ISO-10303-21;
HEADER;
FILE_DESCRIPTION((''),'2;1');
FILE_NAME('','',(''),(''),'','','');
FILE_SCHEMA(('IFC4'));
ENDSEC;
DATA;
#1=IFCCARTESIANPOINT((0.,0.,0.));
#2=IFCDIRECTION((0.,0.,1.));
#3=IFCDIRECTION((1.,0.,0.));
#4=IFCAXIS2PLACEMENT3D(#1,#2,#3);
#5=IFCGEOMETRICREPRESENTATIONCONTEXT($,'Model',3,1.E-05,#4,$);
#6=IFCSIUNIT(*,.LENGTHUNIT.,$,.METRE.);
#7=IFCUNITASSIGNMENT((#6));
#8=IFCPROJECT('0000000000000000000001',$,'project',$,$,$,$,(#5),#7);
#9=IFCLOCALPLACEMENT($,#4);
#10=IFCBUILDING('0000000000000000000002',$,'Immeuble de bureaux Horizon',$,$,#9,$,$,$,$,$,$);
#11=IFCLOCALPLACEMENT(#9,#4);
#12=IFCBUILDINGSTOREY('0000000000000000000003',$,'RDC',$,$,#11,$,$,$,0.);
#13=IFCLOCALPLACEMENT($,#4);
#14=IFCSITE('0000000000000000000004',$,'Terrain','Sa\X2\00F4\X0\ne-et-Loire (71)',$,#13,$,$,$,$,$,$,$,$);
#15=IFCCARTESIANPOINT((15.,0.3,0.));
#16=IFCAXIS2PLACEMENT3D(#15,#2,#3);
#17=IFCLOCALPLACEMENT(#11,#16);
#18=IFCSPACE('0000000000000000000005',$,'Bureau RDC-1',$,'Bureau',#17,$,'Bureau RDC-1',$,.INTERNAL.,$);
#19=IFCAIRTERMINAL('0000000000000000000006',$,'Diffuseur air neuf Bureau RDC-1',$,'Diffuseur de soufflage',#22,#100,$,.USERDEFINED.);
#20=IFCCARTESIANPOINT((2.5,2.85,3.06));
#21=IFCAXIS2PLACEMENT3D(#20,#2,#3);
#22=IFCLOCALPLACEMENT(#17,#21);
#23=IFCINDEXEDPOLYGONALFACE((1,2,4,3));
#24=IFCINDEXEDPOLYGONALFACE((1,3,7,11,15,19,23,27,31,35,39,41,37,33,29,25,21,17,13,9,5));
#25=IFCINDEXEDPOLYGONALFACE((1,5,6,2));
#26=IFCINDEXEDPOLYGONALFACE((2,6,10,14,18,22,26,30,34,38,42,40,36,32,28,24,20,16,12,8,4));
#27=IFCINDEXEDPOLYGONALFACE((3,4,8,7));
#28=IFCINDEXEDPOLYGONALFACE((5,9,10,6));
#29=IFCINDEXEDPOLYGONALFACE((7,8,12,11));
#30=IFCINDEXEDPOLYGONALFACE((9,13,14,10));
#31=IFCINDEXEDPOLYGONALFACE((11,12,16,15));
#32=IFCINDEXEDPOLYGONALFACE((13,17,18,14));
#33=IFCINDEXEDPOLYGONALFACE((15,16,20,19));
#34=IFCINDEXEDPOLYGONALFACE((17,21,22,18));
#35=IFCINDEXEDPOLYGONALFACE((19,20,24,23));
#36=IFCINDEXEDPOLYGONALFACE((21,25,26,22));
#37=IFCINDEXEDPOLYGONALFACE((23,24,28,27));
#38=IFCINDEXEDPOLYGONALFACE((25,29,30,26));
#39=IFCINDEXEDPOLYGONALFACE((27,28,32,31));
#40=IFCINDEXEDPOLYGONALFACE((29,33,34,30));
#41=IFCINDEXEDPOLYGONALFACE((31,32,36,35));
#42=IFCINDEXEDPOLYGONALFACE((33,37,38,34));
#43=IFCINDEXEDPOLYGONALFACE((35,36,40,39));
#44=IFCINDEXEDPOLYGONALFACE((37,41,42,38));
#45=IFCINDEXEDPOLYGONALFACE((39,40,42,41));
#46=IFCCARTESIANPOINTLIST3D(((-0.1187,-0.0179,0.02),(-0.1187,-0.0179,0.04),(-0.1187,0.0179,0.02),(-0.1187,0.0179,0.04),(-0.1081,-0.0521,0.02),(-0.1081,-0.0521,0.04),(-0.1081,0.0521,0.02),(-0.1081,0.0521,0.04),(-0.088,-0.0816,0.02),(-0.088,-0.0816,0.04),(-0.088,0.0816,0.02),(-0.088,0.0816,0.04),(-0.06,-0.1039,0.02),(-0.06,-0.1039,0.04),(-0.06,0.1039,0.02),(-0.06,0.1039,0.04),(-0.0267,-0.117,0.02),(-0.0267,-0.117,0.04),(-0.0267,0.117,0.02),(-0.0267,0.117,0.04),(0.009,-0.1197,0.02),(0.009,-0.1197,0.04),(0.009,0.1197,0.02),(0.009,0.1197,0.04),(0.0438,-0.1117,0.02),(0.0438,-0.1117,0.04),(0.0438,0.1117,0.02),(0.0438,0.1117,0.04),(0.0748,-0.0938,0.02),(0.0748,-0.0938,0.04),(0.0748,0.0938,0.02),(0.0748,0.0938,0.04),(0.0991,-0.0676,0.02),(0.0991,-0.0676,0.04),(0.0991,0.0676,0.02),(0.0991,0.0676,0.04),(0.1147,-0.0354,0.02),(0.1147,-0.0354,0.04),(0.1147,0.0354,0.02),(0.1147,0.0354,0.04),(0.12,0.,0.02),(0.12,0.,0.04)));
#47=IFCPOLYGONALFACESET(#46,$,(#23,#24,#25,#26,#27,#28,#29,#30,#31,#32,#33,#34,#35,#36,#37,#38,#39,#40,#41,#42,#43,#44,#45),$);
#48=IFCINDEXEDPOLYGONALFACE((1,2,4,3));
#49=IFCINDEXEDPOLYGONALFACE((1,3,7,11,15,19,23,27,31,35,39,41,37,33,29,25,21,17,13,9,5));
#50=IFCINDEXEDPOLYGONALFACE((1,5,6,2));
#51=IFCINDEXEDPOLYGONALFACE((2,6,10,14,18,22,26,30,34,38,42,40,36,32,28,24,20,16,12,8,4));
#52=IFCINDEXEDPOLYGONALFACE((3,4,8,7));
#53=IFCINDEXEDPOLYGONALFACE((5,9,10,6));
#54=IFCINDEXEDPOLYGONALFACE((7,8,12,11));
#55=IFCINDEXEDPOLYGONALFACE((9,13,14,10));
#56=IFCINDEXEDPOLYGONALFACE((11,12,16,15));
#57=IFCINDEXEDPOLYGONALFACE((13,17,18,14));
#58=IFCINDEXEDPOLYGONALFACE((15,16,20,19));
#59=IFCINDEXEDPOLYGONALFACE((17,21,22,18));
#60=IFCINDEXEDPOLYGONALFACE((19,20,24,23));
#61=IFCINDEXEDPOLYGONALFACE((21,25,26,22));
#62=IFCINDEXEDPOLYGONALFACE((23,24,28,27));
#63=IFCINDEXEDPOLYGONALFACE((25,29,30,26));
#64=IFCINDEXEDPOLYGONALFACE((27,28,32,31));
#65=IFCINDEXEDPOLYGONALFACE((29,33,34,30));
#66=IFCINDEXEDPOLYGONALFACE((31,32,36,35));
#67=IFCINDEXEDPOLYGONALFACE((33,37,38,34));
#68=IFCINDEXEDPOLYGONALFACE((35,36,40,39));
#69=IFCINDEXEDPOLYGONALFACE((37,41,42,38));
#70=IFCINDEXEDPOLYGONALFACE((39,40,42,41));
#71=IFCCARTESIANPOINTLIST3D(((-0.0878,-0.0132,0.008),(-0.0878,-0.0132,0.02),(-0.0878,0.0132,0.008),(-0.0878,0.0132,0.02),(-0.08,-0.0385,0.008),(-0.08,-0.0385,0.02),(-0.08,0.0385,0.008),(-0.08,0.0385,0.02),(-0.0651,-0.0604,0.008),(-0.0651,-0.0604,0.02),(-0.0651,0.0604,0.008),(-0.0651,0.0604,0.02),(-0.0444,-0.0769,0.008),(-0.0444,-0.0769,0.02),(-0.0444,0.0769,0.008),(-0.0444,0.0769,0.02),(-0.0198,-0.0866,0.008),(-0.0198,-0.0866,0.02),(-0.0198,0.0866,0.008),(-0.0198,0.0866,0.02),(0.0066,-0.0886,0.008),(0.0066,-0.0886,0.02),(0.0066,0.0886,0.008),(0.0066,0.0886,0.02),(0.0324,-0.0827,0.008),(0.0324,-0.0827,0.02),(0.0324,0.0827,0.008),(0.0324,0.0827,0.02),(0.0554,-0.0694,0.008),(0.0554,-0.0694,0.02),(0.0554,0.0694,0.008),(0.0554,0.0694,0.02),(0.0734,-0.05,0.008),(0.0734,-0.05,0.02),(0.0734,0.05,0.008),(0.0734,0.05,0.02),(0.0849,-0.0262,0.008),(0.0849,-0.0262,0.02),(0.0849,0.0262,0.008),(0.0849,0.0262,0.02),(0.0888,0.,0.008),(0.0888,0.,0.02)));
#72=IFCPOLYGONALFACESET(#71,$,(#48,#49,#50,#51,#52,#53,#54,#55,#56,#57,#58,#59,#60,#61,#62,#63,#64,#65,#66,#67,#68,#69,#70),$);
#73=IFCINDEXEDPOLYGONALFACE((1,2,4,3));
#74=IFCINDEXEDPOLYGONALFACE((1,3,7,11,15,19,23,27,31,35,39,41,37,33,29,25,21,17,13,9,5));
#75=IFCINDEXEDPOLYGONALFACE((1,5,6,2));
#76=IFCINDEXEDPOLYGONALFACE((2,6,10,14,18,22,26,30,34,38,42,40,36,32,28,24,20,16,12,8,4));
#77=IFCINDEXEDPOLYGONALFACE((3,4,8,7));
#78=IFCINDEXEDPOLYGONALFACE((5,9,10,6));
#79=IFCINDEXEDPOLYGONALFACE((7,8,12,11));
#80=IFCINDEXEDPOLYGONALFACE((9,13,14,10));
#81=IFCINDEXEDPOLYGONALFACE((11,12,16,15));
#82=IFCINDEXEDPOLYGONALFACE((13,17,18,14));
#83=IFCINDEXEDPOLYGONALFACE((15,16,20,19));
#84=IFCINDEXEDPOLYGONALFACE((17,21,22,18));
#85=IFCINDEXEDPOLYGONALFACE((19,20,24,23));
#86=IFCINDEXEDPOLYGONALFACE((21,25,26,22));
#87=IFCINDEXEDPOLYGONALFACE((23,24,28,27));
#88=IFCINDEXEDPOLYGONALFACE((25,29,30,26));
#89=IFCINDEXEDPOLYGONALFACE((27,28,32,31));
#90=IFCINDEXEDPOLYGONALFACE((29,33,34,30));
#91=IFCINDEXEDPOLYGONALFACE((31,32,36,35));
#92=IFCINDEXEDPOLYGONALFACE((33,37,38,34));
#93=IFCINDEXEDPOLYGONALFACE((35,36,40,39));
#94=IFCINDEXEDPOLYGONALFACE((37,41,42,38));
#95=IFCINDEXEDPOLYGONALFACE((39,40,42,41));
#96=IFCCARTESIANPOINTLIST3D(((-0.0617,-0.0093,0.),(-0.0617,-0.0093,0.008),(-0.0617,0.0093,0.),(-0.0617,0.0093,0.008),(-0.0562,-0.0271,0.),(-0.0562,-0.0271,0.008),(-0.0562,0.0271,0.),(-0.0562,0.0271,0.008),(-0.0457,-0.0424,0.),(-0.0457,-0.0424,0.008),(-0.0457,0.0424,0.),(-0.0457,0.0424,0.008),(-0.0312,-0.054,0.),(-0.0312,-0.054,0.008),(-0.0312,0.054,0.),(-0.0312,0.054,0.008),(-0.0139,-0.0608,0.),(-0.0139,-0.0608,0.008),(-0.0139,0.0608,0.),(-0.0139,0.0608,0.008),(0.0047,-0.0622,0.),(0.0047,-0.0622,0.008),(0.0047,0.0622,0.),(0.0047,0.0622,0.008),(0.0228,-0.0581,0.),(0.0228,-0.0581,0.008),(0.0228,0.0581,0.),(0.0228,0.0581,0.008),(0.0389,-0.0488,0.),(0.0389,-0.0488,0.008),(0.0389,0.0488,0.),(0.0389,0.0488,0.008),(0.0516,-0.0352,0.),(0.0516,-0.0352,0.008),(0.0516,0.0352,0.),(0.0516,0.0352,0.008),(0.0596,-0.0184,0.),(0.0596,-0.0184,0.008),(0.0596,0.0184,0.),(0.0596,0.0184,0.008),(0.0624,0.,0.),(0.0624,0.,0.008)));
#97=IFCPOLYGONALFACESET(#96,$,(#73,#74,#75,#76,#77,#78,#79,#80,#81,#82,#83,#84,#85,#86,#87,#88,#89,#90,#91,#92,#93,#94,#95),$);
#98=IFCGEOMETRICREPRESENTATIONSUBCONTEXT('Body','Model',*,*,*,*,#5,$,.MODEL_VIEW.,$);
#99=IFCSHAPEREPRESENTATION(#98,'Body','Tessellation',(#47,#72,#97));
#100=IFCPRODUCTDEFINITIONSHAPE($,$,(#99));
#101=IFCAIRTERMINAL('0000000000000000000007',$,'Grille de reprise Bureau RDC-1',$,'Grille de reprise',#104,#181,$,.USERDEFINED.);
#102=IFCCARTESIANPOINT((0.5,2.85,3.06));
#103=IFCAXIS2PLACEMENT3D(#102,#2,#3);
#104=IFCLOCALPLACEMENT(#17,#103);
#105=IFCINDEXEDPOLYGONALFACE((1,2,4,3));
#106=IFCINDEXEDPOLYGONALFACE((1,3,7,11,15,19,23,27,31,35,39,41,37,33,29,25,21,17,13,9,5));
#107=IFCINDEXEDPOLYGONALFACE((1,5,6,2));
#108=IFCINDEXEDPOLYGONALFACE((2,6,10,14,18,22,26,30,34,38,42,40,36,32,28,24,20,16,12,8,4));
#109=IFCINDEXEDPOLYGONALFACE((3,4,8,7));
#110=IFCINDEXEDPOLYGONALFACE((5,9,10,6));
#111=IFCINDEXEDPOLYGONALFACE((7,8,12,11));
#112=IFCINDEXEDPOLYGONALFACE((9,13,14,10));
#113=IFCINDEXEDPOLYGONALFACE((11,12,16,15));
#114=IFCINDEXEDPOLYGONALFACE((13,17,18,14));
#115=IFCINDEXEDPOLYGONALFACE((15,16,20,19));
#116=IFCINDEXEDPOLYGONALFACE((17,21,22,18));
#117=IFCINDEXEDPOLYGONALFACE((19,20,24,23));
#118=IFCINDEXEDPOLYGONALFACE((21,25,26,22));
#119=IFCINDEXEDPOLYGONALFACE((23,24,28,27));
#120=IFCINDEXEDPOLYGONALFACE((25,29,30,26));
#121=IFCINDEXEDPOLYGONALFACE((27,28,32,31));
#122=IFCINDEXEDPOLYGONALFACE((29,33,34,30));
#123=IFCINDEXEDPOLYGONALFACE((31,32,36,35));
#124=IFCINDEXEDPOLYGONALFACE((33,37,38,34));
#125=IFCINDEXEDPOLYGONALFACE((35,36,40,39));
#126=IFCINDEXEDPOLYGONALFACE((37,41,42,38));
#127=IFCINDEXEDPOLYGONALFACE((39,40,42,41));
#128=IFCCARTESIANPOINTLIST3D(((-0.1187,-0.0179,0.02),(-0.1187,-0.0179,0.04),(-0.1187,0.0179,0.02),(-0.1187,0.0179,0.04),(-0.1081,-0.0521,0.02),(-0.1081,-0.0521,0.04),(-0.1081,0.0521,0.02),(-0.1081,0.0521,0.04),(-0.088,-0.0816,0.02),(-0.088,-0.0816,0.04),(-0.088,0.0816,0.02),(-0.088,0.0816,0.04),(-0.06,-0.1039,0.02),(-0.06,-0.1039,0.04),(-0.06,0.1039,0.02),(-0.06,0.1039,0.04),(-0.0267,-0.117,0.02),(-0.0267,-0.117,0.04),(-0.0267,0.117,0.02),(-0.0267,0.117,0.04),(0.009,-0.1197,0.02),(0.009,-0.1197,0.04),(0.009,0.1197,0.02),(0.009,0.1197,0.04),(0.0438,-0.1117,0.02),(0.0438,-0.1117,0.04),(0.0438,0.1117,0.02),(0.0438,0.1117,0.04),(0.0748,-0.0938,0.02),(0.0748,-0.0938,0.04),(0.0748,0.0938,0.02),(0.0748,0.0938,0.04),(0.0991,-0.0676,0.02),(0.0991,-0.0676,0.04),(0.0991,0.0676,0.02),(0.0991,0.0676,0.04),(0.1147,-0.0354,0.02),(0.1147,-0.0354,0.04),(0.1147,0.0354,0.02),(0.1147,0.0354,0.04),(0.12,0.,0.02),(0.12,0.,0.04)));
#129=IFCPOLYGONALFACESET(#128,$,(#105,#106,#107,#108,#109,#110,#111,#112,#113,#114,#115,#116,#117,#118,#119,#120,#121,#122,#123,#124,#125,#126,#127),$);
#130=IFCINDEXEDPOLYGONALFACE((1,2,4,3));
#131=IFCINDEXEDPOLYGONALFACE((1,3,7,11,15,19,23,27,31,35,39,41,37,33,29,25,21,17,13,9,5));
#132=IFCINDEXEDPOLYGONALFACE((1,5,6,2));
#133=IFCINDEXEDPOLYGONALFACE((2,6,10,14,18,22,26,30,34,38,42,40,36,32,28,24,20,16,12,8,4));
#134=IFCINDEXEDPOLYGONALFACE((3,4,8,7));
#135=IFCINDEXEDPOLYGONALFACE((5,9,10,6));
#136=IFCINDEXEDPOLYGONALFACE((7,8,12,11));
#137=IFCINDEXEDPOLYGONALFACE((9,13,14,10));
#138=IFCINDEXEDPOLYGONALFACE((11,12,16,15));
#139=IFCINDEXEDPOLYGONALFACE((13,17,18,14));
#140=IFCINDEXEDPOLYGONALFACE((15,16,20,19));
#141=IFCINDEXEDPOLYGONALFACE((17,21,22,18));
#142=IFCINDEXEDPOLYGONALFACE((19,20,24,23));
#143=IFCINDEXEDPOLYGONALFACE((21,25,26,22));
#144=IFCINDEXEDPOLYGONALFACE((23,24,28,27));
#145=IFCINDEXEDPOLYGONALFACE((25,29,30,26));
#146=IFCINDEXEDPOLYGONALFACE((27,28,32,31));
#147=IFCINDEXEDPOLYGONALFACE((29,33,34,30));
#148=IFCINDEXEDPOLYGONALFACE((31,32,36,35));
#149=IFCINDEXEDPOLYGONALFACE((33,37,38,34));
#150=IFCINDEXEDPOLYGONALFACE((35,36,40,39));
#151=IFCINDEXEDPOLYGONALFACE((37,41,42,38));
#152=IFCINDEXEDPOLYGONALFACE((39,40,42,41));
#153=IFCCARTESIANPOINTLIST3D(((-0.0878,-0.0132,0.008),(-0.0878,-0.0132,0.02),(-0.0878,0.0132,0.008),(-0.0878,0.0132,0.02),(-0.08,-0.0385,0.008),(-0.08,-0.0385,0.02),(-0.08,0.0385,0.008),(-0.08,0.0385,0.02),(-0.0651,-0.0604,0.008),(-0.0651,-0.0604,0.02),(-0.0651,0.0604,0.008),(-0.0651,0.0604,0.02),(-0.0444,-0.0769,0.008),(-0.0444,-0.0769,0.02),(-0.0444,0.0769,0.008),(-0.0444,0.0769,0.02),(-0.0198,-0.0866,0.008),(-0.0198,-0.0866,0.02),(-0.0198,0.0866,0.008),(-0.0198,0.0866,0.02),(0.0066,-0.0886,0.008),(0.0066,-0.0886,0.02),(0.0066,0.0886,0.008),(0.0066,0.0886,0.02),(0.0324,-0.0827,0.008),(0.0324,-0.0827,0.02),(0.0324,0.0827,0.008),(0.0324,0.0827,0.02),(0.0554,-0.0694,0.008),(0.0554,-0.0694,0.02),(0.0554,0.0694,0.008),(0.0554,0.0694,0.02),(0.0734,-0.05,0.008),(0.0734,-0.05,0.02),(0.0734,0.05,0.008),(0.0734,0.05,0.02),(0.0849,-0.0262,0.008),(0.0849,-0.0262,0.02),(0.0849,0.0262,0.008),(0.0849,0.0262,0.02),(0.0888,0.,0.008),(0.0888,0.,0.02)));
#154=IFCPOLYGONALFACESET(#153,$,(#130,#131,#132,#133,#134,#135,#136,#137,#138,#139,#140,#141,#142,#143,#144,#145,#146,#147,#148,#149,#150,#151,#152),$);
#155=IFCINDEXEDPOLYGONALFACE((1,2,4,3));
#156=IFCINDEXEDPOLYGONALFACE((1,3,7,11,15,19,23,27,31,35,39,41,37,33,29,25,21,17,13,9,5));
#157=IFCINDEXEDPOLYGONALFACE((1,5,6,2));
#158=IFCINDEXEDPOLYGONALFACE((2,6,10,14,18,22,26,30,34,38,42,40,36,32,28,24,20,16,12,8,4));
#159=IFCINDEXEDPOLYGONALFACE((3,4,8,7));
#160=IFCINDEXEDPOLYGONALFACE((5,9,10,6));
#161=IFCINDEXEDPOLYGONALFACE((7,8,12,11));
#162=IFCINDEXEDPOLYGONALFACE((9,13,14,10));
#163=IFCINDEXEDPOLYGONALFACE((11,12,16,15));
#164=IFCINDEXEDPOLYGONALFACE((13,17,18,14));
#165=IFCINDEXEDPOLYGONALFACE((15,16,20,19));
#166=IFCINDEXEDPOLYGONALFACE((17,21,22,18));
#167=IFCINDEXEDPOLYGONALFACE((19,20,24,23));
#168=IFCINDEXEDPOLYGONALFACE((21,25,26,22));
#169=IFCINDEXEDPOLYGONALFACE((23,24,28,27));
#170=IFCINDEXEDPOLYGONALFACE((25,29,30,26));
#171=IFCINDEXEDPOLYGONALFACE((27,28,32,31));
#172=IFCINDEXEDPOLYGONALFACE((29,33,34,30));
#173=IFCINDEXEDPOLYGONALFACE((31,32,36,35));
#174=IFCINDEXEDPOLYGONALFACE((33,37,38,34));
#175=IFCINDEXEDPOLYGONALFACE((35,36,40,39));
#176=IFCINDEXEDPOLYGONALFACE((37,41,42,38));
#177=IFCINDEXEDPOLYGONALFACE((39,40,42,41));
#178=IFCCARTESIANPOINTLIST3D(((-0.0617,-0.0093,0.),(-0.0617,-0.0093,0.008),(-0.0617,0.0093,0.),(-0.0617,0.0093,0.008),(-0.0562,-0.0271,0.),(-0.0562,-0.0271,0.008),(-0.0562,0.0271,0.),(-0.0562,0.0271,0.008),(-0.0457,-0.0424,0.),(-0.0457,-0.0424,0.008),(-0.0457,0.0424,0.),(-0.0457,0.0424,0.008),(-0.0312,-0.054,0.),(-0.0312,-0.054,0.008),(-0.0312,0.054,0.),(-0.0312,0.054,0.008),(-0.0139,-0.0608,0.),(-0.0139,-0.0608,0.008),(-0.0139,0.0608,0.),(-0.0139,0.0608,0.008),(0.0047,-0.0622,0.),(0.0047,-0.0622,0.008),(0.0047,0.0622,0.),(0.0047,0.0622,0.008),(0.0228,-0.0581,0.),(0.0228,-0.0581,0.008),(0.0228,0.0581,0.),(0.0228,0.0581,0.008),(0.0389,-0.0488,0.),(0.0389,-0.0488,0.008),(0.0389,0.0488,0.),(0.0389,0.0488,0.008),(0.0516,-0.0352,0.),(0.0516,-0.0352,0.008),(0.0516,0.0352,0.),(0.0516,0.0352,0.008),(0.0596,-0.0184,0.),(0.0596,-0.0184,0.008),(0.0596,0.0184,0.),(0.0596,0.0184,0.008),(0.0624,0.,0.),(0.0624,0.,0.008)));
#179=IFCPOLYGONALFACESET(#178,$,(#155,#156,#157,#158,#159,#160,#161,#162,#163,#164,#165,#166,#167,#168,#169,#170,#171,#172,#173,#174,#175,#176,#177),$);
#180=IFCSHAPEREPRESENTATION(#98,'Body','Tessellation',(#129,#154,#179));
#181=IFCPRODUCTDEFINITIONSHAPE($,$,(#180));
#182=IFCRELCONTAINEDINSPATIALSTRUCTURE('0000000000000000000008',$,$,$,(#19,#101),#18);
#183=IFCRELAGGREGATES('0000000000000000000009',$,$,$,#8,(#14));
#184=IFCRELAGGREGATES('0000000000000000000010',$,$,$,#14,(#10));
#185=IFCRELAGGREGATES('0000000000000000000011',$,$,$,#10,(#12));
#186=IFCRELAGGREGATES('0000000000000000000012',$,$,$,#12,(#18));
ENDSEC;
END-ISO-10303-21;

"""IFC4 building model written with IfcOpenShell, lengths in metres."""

from ifc_helpers import new_model, si_unit, frame, origin_with_axes, place, context, subcontext, project, spatial, circle, extrude, element, save


model = new_model("IFC4")

# Units and contexts
model_context = context("Model", 3, precision=1e-05, world=origin_with_axes())
body_context = subcontext(model_context, "Body", "Model", "MODEL_VIEW")
ifc_project = project(units=[si_unit("LENGTHUNIT", "METRE")], contexts=[model_context])

# Site, building, storey
site_placement = place(None, origin_with_axes())
site = spatial("IfcSite", under=ifc_project, at=site_placement, Name="Terrain", Description="Saône-et-Loire (71)")
building_placement = place(None, origin_with_axes())
building = spatial("IfcBuilding", under=site, at=building_placement, Name="Immeuble de bureaux Horizon")
storey_placement = place(building_placement, origin_with_axes())
storey = spatial("IfcBuildingStorey", under=building, at=storey_placement, Name="RDC", Elevation=0.0)

# Shared definitions
space_1_placement = place(storey_placement, frame((15.0, 0.3, 0.0), z_axis=(0.0, 0.0, 1.0), x_axis=(1.0, 0.0, 0.0)))
space_1 = spatial("IfcSpace", under=storey, at=space_1_placement, Name="Bureau RDC-1", ObjectType="Bureau", LongName="Bureau RDC-1", PredefinedType="INTERNAL")

# Air terminal
air_terminal_1_placement = place(space_1_placement, frame((2.5, 2.85, 3.06), z_axis=(0.0, 0.0, 1.0), x_axis=(1.0, 0.0, 0.0)))
element("IfcAirTerminal", 1, at=air_terminal_1_placement, inside=space_1, Name="Diffuseur air neuf Bureau RDC-1", ObjectType="Diffuseur de soufflage", PredefinedType="USERDEFINED", context=body_context, shape_type="SweptSolid", body=[
    extrude(circle(Radius=0.12), frame((0.0, 0.0, 0.02), z_axis=(0.0, 0.0, 1.0), x_axis=(1.0, 0.0, 0.0)), (0.0, 0.0, 1.0), 0.02),
    extrude(circle(Radius=0.0888), frame((0.0, 0.0, 0.008), z_axis=(0.0, 0.0, 1.0), x_axis=(1.0, 0.0, 0.0)), (0.0, 0.0, 1.0), 0.012),
    extrude(circle(Radius=0.0624), origin_with_axes(), (0.0, 0.0, 1.0), 0.008),
])

# Air terminal
air_terminal_2_placement = place(space_1_placement, frame((0.5, 2.85, 3.06), z_axis=(0.0, 0.0, 1.0), x_axis=(1.0, 0.0, 0.0)))
element("IfcAirTerminal", 2, at=air_terminal_2_placement, inside=space_1, Name="Grille de reprise Bureau RDC-1", ObjectType="Grille de reprise", PredefinedType="USERDEFINED", context=body_context, shape_type="SweptSolid", body=[
    extrude(circle(Radius=0.12), frame((0.0, 0.0, 0.02), z_axis=(0.0, 0.0, 1.0), x_axis=(1.0, 0.0, 0.0)), (0.0, 0.0, 1.0), 0.02),
    extrude(circle(Radius=0.0888), frame((0.0, 0.0, 0.008), z_axis=(0.0, 0.0, 1.0), x_axis=(1.0, 0.0, 0.0)), (0.0, 0.0, 1.0), 0.012),
    extrude(circle(Radius=0.0624), origin_with_axes(), (0.0, 0.0, 1.0), 0.008),
])

save(model, "model.ifc")
